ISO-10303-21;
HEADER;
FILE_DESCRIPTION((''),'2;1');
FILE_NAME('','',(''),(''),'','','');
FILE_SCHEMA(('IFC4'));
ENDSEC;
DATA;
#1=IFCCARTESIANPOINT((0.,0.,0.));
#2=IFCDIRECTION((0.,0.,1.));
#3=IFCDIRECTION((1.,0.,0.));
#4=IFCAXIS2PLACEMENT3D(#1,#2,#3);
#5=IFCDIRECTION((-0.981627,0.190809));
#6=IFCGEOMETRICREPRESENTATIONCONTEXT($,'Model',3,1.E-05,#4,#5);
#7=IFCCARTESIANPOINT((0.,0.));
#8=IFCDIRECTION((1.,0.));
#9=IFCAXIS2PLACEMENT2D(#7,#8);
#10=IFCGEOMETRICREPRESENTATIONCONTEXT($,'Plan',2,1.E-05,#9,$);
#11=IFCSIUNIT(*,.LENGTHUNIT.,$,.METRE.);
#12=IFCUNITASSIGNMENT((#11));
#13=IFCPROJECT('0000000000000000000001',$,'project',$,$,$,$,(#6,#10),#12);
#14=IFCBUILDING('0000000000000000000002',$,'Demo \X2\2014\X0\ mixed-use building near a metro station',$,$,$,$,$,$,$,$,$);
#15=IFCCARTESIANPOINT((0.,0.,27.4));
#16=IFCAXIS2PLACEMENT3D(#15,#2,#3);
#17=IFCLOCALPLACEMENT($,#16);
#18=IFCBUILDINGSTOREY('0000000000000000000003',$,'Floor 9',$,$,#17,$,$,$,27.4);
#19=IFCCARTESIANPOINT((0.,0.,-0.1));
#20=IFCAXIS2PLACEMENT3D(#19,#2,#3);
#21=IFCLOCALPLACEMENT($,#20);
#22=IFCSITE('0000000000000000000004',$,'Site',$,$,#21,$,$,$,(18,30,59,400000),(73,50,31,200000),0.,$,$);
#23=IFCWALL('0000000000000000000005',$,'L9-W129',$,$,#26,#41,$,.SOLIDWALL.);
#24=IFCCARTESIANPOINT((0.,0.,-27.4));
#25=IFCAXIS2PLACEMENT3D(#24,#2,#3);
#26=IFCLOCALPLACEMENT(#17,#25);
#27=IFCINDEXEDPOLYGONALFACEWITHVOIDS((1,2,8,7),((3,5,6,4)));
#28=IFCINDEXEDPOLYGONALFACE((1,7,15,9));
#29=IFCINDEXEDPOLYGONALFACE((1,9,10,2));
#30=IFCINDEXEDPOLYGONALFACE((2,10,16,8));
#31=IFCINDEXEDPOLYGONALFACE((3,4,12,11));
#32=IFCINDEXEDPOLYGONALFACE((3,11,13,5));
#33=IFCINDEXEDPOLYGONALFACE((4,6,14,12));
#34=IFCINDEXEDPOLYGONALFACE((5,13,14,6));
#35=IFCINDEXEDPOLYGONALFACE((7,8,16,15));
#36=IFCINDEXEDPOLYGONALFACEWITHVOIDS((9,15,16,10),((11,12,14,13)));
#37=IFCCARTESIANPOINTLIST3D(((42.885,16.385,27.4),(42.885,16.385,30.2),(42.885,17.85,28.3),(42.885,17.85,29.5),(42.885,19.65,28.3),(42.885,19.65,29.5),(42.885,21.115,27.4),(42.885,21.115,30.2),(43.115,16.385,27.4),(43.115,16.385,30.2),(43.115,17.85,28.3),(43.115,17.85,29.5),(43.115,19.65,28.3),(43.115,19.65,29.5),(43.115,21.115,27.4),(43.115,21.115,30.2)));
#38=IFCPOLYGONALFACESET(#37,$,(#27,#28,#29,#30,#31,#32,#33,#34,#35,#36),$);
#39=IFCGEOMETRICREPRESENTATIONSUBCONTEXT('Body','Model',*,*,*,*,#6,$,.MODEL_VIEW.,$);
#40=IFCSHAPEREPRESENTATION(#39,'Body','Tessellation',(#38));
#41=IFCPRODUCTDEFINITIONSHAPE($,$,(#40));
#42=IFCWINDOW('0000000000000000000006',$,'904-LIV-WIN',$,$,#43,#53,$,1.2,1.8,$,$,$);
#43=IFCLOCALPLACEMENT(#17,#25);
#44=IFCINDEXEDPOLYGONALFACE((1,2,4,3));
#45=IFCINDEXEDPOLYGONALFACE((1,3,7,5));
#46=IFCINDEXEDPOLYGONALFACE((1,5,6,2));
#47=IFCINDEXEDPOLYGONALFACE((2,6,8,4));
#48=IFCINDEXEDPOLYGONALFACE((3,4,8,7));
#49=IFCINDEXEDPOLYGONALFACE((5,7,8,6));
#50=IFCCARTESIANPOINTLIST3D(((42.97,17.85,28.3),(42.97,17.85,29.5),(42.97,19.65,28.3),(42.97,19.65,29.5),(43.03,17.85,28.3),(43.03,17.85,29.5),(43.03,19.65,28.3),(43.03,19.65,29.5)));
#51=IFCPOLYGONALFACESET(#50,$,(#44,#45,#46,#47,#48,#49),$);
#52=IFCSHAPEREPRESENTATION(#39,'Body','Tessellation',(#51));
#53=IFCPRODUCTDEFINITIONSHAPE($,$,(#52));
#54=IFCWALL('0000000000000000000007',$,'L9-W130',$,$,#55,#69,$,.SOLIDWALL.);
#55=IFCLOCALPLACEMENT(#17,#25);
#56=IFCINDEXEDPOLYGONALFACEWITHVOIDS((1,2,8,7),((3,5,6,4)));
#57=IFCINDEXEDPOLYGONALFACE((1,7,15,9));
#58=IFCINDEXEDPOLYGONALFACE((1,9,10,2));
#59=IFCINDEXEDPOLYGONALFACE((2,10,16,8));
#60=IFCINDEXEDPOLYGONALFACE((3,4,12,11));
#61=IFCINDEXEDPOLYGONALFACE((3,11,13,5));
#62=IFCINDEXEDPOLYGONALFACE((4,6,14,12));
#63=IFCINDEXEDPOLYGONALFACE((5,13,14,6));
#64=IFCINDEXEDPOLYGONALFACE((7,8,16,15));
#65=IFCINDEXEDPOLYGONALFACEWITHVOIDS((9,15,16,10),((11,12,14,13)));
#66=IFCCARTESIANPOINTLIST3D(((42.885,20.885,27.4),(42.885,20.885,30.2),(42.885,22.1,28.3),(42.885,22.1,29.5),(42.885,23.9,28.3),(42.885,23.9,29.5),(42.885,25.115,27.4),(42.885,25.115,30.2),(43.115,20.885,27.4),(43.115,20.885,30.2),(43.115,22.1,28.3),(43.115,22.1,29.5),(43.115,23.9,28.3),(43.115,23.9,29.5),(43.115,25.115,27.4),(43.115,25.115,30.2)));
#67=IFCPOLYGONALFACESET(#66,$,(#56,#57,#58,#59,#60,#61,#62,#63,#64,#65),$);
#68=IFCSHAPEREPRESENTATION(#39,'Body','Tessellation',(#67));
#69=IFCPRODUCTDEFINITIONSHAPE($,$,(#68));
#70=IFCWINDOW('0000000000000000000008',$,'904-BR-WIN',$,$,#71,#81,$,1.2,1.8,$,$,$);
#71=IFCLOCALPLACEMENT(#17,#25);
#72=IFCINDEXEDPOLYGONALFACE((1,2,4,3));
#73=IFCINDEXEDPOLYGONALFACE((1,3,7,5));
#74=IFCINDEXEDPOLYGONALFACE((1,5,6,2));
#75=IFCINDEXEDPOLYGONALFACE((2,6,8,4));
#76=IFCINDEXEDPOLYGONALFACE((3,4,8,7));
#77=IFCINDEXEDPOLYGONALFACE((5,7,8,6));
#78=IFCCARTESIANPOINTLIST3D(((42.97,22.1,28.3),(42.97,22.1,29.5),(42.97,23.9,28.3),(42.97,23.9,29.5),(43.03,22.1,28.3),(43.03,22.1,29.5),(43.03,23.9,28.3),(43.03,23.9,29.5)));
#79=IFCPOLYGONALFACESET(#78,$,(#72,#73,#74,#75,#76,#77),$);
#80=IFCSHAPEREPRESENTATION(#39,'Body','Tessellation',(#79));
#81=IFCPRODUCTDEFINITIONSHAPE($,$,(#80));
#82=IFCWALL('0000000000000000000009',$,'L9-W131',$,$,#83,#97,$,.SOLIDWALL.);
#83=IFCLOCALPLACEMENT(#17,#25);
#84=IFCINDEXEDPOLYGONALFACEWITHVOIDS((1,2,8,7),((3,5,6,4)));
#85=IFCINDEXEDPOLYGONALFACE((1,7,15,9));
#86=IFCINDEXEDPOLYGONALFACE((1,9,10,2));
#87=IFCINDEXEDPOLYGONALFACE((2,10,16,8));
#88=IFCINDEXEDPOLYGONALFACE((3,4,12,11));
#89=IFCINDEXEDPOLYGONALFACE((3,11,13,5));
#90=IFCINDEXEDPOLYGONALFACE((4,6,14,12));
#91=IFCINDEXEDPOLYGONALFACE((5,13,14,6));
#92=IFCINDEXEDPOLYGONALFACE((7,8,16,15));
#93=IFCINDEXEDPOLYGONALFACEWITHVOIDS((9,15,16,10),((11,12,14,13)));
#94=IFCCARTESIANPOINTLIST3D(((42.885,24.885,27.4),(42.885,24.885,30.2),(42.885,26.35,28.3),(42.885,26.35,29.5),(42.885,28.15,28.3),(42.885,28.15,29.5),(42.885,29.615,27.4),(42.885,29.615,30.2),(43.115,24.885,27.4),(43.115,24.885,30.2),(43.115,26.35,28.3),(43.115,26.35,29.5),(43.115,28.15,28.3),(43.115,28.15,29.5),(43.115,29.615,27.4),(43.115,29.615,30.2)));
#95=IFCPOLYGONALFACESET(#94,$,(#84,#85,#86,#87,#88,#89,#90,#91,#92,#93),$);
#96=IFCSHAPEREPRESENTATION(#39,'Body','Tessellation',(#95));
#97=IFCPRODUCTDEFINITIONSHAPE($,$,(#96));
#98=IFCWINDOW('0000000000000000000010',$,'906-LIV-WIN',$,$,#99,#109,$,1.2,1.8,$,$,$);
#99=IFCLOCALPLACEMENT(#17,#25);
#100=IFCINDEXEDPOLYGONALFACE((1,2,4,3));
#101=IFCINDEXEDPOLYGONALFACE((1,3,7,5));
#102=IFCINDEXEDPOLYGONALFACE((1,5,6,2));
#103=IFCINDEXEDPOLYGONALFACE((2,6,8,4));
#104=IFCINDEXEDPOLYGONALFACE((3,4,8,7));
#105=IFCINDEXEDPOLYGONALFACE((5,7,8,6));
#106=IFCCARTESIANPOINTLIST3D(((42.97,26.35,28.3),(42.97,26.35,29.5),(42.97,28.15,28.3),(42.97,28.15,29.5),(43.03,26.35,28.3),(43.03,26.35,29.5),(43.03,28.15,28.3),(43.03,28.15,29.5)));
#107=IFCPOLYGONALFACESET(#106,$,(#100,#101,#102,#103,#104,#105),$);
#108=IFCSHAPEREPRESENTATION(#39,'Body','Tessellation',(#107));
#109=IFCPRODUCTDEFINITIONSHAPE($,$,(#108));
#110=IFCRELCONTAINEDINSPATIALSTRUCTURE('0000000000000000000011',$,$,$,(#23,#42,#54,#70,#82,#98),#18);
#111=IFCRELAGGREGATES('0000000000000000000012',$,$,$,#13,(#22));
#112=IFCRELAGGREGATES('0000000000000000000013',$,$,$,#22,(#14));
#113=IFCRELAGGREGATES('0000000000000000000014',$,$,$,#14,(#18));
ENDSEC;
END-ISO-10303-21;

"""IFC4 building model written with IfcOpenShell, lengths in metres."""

from ifc_helpers import new_model, si_unit, direction, frame, origin_with_axes, origin_2d_with_axis, place, context, subcontext, project, spatial, line, indexed_curve, outline, extrude, element, fill, save


model = new_model("IFC4")

# Units and contexts
model_context = context("Model", 3, precision=1e-05, world=origin_with_axes(), true_north=direction((-0.981627, 0.190809)))
plan_context = context("Plan", 2, precision=1e-05, world=origin_2d_with_axis())
body_context = subcontext(model_context, "Body", "Model", "MODEL_VIEW")
ifc_project = project(units=[si_unit("LENGTHUNIT", "METRE")], contexts=[model_context, plan_context])

# Site, building, storey
site_placement = place(None, frame((0.0, 0.0, -0.1), z_axis=(0.0, 0.0, 1.0), x_axis=(1.0, 0.0, 0.0)))
site = spatial("IfcSite", under=ifc_project, at=site_placement, Name="Site", RefLatitude=(18, 30, 59, 400000), RefLongitude=(73, 50, 31, 200000), RefElevation=0.0)
building = spatial("IfcBuilding", under=site, Name="Demo — mixed-use building near a metro station")
storey_placement = place(None, frame((0.0, 0.0, 27.4), z_axis=(0.0, 0.0, 1.0), x_axis=(1.0, 0.0, 0.0)))
storey = spatial("IfcBuildingStorey", under=building, at=storey_placement, Name="Floor 9", Elevation=27.4)

# Walls, openings, windows
wall_1_placement = place(storey_placement, frame((0.0, 0.0, -27.4), z_axis=(0.0, 0.0, 1.0), x_axis=(1.0, 0.0, 0.0)))
wall_1 = element("IfcWall", 1, at=wall_1_placement, inside=storey, Name="L9-W129", PredefinedType="SOLIDWALL", context=body_context, shape_type="SweptSolid", body=[
    extrude(outline(indexed_curve([(42.885, 16.385), (42.885, 21.115), (43.115, 21.115), (43.115, 16.385)], segments=[line(1, 2, 3, 4, 1)])), frame((0.0, 0.0, 27.4), z_axis=(0.0, 0.0, 1.0), x_axis=(1.0, 0.0, 0.0)), (0.0, 0.0, 1.0), 2.8),
])
opening_1_placement = place(wall_1_placement, origin_with_axes())
opening_1 = element("IfcOpeningElement", 2, at=opening_1_placement, cuts=wall_1, context=body_context, shape_type="SweptSolid", body=[
    extrude(outline(indexed_curve([(42.835, 17.85), (42.835, 19.65), (43.165, 19.65), (43.165, 17.85)], segments=[line(1, 2, 3, 4, 1)])), frame((0.0, 0.0, 28.3), z_axis=(0.0, 0.0, 1.0), x_axis=(1.0, 0.0, 0.0)), (0.0, 0.0, 1.0), 1.2),
])
window_1_placement = place(storey_placement, frame((0.0, 0.0, -27.4), z_axis=(0.0, 0.0, 1.0), x_axis=(1.0, 0.0, 0.0)))
window_1 = element("IfcWindow", 3, at=window_1_placement, inside=storey, Name="904-LIV-WIN", OverallHeight=1.2, OverallWidth=1.8, context=body_context, shape_type="SweptSolid", body=[
    extrude(outline(indexed_curve([(42.97, 17.85), (42.97, 19.65), (43.03, 19.65), (43.03, 17.85)], segments=[line(1, 2, 3, 4, 1)])), frame((0.0, 0.0, 28.3), z_axis=(0.0, 0.0, 1.0), x_axis=(1.0, 0.0, 0.0)), (0.0, 0.0, 1.0), 1.2),
])
fill(opening_1, window_1)
wall_2_placement = place(storey_placement, frame((0.0, 0.0, -27.4), z_axis=(0.0, 0.0, 1.0), x_axis=(1.0, 0.0, 0.0)))
wall_2 = element("IfcWall", 4, at=wall_2_placement, inside=storey, Name="L9-W130", PredefinedType="SOLIDWALL", context=body_context, shape_type="SweptSolid", body=[
    extrude(outline(indexed_curve([(42.885, 20.885), (42.885, 25.115), (43.115, 25.115), (43.115, 20.885)], segments=[line(1, 2, 3, 4, 1)])), frame((0.0, 0.0, 27.4), z_axis=(0.0, 0.0, 1.0), x_axis=(1.0, 0.0, 0.0)), (0.0, 0.0, 1.0), 2.8),
])
opening_2_placement = place(wall_2_placement, origin_with_axes())
opening_2 = element("IfcOpeningElement", 5, at=opening_2_placement, cuts=wall_2, context=body_context, shape_type="SweptSolid", body=[
    extrude(outline(indexed_curve([(42.835, 22.1), (42.835, 23.9), (43.165, 23.9), (43.165, 22.1)], segments=[line(1, 2, 3, 4, 1)])), frame((0.0, 0.0, 28.3), z_axis=(0.0, 0.0, 1.0), x_axis=(1.0, 0.0, 0.0)), (0.0, 0.0, 1.0), 1.2),
])
window_2_placement = place(storey_placement, frame((0.0, 0.0, -27.4), z_axis=(0.0, 0.0, 1.0), x_axis=(1.0, 0.0, 0.0)))
window_2 = element("IfcWindow", 6, at=window_2_placement, inside=storey, Name="904-BR-WIN", OverallHeight=1.2, OverallWidth=1.8, context=body_context, shape_type="SweptSolid", body=[
    extrude(outline(indexed_curve([(42.97, 22.1), (42.97, 23.9), (43.03, 23.9), (43.03, 22.1)], segments=[line(1, 2, 3, 4, 1)])), frame((0.0, 0.0, 28.3), z_axis=(0.0, 0.0, 1.0), x_axis=(1.0, 0.0, 0.0)), (0.0, 0.0, 1.0), 1.2),
])
fill(opening_2, window_2)
wall_3_placement = place(storey_placement, frame((0.0, 0.0, -27.4), z_axis=(0.0, 0.0, 1.0), x_axis=(1.0, 0.0, 0.0)))
wall_3 = element("IfcWall", 7, at=wall_3_placement, inside=storey, Name="L9-W131", PredefinedType="SOLIDWALL", context=body_context, shape_type="SweptSolid", body=[
    extrude(outline(indexed_curve([(42.885, 24.885), (42.885, 29.615), (43.115, 29.615), (43.115, 24.885)], segments=[line(1, 2, 3, 4, 1)])), frame((0.0, 0.0, 27.4), z_axis=(0.0, 0.0, 1.0), x_axis=(1.0, 0.0, 0.0)), (0.0, 0.0, 1.0), 2.8),
])
opening_3_placement = place(wall_3_placement, origin_with_axes())
opening_3 = element("IfcOpeningElement", 8, at=opening_3_placement, cuts=wall_3, context=body_context, shape_type="SweptSolid", body=[
    extrude(outline(indexed_curve([(42.835, 26.35), (42.835, 28.15), (43.165, 28.15), (43.165, 26.35)], segments=[line(1, 2, 3, 4, 1)])), frame((0.0, 0.0, 28.3), z_axis=(0.0, 0.0, 1.0), x_axis=(1.0, 0.0, 0.0)), (0.0, 0.0, 1.0), 1.2),
])
window_3_placement = place(storey_placement, frame((0.0, 0.0, -27.4), z_axis=(0.0, 0.0, 1.0), x_axis=(1.0, 0.0, 0.0)))
window_3 = element("IfcWindow", 9, at=window_3_placement, inside=storey, Name="906-LIV-WIN", OverallHeight=1.2, OverallWidth=1.8, context=body_context, shape_type="SweptSolid", body=[
    extrude(outline(indexed_curve([(42.97, 26.35), (42.97, 28.15), (43.03, 28.15), (43.03, 26.35)], segments=[line(1, 2, 3, 4, 1)])), frame((0.0, 0.0, 28.3), z_axis=(0.0, 0.0, 1.0), x_axis=(1.0, 0.0, 0.0)), (0.0, 0.0, 1.0), 1.2),
])
fill(opening_3, window_3)

save(model, "model.ifc")
